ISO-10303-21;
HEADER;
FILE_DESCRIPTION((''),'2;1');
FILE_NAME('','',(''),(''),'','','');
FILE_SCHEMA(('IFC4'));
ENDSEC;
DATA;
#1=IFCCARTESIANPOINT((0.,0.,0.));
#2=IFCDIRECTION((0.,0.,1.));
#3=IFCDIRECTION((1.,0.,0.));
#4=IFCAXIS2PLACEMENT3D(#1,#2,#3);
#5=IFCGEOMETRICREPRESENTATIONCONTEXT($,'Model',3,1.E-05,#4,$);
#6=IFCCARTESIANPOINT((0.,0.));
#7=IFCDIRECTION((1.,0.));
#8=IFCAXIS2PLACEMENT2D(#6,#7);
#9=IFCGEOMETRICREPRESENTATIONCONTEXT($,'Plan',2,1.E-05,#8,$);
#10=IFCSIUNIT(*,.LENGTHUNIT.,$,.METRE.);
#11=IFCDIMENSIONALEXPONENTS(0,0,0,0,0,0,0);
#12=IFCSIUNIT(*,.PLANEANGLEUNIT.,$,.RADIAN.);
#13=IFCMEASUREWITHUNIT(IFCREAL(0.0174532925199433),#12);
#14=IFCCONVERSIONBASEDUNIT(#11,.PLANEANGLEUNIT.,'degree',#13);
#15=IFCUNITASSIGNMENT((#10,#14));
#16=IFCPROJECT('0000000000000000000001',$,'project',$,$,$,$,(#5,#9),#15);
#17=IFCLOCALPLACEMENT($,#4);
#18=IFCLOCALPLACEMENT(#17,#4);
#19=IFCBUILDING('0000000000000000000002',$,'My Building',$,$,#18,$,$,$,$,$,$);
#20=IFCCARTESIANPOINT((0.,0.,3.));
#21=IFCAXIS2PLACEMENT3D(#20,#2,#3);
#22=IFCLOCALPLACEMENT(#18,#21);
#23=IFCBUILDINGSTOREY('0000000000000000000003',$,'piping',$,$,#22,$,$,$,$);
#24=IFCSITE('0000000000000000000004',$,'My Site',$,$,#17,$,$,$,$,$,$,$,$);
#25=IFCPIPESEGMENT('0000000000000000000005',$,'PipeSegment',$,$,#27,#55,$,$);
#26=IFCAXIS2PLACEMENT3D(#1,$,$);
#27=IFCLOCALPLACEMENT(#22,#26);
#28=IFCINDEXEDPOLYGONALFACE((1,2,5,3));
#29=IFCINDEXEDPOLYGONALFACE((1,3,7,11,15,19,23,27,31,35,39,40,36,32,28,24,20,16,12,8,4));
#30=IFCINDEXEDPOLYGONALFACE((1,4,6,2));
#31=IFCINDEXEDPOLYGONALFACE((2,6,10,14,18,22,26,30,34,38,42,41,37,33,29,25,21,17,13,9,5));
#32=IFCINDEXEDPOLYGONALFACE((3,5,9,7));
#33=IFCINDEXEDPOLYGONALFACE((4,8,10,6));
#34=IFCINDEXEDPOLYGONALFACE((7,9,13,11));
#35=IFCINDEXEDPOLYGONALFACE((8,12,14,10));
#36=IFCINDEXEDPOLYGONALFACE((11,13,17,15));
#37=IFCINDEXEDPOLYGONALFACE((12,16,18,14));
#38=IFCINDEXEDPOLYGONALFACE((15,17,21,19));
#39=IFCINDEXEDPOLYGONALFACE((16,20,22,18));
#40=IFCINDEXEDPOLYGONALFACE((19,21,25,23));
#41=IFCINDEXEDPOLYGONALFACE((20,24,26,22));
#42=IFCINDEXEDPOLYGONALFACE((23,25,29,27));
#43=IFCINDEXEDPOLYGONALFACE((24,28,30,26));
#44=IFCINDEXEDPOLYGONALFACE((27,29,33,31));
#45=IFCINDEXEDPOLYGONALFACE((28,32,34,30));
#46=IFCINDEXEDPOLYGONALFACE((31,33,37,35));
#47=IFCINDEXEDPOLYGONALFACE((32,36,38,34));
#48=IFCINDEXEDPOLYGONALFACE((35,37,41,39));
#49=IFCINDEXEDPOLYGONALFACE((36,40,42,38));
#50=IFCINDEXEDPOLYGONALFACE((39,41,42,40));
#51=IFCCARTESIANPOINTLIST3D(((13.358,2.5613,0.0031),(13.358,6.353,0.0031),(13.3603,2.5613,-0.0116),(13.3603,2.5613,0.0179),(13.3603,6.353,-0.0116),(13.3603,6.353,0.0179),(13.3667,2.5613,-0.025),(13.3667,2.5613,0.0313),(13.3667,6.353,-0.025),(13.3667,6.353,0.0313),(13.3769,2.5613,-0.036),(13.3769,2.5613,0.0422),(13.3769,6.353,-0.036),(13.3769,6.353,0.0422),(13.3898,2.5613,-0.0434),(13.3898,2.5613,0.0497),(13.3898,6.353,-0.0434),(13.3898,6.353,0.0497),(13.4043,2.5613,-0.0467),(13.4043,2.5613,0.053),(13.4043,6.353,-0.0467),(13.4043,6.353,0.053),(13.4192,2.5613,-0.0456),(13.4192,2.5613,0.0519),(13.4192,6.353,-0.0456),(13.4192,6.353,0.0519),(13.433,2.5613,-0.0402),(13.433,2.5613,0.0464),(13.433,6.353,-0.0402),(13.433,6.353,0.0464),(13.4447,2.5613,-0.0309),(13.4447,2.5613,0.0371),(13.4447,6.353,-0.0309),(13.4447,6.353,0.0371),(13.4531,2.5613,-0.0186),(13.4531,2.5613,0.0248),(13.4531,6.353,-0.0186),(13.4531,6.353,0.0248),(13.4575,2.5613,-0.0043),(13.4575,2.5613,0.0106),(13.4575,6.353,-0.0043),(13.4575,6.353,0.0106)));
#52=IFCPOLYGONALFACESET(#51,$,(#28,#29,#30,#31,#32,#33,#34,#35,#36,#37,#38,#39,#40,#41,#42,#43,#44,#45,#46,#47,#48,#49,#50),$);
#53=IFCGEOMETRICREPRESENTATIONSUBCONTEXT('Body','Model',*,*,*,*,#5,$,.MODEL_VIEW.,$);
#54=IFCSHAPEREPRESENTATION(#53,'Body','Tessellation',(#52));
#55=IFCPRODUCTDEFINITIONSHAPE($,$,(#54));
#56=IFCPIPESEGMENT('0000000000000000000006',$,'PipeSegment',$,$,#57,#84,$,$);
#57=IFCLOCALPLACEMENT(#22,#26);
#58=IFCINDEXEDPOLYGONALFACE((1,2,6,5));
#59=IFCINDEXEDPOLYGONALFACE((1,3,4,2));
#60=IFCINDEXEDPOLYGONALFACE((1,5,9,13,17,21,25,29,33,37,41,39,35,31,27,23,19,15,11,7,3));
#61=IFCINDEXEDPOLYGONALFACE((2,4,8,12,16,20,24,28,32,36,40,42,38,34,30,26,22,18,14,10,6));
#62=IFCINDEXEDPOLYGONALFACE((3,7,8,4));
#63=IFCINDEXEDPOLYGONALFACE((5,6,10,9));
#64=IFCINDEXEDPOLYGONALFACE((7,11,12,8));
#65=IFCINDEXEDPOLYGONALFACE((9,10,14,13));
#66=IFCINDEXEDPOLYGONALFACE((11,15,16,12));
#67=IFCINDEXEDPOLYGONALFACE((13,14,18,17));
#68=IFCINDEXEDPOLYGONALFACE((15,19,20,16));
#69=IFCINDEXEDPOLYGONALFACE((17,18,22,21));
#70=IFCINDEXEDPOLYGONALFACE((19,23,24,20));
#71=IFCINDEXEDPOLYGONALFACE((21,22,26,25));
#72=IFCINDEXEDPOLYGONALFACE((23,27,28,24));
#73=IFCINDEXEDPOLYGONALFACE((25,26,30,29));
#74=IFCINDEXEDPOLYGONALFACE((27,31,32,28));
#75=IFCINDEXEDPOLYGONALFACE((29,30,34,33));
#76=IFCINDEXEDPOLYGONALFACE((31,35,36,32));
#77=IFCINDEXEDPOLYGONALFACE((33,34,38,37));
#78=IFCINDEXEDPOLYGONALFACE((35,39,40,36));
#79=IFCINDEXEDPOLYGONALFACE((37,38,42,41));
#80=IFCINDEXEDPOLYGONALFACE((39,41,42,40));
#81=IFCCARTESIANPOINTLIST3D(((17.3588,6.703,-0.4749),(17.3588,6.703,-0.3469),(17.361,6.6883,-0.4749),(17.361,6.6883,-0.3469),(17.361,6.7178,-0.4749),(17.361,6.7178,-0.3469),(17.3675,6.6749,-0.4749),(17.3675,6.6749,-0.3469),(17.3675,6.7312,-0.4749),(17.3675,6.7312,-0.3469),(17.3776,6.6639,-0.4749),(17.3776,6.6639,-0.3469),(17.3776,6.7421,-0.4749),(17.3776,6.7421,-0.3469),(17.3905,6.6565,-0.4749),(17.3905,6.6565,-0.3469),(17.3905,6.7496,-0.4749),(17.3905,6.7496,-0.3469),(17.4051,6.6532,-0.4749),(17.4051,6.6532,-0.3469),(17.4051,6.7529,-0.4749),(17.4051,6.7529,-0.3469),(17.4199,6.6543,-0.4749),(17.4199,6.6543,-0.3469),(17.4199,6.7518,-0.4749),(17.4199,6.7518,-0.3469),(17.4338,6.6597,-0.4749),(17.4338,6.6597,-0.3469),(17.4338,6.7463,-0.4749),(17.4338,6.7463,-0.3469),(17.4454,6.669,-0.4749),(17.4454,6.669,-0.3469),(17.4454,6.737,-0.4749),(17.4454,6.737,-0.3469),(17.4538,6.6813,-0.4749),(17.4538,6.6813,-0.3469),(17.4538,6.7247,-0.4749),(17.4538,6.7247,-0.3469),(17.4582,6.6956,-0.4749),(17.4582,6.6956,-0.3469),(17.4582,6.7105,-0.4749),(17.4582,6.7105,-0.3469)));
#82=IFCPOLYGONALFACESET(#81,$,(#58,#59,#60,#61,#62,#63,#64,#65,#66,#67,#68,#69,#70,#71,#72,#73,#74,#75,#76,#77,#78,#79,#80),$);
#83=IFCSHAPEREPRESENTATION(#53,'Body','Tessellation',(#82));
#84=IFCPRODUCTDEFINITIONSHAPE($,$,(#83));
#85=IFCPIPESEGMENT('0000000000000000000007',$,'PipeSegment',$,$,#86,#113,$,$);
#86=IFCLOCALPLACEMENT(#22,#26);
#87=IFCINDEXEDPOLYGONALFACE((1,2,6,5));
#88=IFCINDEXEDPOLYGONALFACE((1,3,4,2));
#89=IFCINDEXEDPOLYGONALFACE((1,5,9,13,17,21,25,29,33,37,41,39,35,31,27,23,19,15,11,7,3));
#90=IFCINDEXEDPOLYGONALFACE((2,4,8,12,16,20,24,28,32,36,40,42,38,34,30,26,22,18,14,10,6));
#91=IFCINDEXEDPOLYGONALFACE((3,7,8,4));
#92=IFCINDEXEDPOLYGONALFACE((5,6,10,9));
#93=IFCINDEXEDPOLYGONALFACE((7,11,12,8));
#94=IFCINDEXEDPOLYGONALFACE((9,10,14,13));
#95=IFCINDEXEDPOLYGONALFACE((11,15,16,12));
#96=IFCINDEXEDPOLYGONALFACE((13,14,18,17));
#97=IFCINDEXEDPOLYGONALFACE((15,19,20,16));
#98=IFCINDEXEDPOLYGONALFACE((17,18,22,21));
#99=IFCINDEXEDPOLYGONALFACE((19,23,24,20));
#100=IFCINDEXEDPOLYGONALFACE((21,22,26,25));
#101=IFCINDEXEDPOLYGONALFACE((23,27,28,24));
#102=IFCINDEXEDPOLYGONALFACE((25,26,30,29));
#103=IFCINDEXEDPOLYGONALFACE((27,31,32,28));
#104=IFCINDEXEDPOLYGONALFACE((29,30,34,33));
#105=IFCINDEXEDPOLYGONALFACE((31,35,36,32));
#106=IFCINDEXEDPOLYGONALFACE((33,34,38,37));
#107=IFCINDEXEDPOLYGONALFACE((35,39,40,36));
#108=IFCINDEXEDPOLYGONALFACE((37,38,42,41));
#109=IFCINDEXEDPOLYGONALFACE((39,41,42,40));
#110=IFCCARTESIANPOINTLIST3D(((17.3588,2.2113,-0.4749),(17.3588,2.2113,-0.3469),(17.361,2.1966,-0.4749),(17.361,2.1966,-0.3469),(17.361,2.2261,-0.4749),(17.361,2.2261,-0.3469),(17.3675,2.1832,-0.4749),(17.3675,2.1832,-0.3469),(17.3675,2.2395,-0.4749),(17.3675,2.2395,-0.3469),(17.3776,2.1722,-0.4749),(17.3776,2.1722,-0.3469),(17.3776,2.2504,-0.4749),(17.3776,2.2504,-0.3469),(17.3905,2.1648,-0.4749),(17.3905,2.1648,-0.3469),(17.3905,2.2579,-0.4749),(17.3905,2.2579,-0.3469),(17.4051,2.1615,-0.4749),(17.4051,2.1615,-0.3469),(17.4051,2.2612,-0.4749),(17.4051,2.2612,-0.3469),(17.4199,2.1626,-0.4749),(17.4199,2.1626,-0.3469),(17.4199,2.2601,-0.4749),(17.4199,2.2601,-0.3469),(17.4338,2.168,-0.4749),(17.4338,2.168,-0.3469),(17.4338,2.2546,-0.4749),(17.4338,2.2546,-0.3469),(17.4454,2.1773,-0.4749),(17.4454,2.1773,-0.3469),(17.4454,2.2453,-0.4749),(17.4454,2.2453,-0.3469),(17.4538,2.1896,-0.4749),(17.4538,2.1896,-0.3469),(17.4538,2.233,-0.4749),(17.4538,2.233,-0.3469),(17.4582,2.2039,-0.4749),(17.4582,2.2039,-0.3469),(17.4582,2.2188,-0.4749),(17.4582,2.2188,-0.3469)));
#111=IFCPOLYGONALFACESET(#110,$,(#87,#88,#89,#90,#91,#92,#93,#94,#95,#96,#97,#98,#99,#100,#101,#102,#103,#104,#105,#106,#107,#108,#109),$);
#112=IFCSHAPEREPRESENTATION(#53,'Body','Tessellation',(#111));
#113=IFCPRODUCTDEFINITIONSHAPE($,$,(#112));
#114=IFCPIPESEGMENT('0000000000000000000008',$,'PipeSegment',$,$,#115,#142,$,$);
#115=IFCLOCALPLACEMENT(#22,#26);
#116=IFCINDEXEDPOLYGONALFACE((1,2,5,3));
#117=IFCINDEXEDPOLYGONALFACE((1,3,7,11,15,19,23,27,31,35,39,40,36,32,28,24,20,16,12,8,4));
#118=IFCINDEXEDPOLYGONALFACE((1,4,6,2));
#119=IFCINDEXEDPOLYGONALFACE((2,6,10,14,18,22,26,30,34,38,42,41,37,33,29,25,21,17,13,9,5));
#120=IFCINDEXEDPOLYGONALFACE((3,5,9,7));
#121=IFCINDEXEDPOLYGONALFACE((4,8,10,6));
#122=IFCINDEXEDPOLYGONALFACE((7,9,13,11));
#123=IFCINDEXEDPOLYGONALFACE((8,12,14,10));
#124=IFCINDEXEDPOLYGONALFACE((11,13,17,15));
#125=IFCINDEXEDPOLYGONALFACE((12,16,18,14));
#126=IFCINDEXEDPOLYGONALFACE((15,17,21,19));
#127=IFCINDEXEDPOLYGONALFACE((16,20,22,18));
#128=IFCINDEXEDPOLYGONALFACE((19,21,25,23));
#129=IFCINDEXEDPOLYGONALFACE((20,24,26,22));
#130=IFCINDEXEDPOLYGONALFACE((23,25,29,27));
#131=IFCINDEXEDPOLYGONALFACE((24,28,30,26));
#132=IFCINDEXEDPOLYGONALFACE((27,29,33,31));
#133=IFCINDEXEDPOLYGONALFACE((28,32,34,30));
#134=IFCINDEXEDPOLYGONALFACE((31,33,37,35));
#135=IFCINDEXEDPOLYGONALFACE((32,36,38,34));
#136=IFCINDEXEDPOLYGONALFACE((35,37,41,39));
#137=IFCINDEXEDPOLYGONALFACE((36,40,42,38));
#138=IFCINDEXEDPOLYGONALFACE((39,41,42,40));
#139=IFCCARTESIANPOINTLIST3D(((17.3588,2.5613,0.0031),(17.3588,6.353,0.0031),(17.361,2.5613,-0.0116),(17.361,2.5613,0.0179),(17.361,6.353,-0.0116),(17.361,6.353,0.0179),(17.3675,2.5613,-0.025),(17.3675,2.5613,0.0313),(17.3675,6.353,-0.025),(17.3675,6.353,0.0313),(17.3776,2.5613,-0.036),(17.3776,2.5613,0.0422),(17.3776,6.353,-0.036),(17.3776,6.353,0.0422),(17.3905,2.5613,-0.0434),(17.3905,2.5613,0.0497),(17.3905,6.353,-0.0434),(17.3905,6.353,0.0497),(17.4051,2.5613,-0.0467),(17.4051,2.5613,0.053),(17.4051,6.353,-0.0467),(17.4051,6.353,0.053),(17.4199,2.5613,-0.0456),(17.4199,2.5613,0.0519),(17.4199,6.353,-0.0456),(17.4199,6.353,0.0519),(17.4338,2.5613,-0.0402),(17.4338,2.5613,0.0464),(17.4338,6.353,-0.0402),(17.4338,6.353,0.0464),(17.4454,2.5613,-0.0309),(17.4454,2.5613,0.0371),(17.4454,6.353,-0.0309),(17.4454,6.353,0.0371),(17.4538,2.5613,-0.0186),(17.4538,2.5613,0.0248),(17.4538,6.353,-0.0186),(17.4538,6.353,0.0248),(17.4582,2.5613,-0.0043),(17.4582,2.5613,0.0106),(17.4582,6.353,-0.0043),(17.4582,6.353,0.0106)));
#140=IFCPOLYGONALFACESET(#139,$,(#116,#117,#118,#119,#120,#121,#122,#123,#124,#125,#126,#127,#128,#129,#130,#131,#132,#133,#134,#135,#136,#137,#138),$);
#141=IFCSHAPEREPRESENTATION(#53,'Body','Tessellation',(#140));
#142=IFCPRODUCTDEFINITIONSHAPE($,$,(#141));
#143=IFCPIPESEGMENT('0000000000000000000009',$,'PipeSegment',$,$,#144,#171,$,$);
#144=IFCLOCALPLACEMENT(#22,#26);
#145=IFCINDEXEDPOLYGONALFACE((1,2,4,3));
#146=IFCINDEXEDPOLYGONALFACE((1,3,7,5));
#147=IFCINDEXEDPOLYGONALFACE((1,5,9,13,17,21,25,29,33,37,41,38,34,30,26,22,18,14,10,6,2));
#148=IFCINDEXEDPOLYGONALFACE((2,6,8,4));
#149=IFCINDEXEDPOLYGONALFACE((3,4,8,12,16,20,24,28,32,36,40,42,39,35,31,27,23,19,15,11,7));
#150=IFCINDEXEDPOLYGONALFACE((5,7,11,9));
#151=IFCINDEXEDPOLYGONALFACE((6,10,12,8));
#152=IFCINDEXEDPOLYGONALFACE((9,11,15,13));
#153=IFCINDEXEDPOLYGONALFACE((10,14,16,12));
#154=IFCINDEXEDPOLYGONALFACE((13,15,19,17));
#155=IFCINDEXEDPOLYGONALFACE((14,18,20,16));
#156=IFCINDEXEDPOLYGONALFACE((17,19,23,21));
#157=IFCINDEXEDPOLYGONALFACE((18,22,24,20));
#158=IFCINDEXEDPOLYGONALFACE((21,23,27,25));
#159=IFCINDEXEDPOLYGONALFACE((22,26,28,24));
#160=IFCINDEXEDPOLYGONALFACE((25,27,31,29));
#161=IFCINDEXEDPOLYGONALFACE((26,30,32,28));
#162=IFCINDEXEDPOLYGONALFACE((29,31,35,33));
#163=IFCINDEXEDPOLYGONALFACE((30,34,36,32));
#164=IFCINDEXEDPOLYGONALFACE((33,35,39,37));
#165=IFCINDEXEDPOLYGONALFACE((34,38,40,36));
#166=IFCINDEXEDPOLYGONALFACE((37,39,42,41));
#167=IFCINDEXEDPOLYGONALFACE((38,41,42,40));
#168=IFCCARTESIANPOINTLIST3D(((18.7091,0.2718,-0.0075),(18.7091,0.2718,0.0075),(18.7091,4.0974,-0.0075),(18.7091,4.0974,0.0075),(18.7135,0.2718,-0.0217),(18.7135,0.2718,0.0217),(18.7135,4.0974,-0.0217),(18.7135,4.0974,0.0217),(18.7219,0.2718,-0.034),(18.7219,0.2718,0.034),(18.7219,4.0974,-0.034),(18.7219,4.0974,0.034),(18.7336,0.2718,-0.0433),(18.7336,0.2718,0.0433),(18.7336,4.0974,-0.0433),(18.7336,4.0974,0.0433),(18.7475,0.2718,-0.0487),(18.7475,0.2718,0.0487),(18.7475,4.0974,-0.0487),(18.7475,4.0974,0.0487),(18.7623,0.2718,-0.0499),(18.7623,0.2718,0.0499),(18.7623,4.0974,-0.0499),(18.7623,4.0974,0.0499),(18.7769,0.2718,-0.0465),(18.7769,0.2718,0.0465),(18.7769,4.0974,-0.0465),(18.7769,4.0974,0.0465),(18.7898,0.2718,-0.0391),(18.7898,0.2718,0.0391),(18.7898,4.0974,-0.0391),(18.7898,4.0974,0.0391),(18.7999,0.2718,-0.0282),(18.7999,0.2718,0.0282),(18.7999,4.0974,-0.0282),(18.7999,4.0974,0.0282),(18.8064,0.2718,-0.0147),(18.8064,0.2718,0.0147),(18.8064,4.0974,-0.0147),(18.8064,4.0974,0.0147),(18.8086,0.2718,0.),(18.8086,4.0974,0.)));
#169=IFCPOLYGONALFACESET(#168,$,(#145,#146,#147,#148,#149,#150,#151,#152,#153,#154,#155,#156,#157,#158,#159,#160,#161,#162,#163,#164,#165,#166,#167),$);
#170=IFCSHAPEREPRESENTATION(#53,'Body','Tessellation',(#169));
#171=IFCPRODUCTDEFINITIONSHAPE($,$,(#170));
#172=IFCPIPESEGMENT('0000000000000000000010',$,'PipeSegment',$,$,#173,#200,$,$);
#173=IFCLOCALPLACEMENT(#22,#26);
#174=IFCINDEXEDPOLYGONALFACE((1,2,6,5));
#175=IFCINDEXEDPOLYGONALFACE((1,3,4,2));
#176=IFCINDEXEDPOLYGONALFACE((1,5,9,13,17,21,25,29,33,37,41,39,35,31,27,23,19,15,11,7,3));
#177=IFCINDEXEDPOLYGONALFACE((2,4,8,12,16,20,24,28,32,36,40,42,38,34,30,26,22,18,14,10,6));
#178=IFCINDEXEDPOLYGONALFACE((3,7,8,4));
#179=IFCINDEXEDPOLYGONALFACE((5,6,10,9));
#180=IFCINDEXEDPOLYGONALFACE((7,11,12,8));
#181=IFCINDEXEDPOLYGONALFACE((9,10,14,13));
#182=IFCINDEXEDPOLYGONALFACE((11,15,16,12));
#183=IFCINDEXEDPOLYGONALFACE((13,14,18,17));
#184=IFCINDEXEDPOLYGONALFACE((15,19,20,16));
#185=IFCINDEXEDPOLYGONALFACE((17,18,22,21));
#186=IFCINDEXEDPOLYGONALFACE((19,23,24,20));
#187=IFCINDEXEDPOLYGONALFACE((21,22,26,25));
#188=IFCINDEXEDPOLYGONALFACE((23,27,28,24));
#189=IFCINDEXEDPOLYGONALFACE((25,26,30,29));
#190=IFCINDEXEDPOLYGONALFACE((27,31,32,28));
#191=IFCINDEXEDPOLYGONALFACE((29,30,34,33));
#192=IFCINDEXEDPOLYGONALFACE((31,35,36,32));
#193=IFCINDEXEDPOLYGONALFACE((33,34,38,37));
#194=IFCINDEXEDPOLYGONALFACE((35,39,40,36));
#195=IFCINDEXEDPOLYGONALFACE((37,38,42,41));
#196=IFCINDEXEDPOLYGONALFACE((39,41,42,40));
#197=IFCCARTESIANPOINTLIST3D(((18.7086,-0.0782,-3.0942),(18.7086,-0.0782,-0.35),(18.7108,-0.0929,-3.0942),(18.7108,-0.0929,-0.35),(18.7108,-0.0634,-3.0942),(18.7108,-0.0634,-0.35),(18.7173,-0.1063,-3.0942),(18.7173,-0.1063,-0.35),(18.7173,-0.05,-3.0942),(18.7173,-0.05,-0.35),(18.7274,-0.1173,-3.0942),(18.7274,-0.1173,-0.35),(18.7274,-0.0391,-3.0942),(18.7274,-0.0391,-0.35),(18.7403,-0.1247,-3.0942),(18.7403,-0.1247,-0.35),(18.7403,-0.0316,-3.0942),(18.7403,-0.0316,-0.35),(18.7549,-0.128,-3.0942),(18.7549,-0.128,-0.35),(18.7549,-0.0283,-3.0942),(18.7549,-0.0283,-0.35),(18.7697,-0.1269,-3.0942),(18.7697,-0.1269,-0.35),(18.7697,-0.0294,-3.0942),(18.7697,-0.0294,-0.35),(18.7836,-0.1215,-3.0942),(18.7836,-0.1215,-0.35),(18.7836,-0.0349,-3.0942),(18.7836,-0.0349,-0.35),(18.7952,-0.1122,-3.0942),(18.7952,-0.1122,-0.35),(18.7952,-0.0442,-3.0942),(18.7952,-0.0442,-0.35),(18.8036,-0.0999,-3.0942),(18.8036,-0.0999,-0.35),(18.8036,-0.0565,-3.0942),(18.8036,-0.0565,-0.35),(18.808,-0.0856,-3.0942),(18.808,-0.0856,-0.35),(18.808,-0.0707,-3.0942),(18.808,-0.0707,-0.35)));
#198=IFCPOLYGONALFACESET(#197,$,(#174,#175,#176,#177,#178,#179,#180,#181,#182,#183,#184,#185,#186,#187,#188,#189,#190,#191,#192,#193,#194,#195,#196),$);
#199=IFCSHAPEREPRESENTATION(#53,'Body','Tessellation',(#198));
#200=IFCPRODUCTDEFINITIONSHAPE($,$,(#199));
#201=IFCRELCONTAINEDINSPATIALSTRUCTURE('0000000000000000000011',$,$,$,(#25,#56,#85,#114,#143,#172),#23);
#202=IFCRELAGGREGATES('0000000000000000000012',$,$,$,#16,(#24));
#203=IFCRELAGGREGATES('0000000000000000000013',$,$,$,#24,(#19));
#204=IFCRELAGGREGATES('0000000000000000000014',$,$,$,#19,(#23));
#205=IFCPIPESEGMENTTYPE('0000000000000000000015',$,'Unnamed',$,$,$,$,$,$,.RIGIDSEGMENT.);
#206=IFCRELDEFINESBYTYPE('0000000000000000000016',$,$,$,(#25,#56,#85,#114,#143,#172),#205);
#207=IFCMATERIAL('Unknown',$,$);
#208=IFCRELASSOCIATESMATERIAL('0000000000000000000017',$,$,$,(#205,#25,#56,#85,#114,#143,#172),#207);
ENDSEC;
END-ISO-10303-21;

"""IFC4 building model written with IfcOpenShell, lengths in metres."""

from ifc_helpers import new_model, entity, si_unit, converted_unit, frame, origin_with_axes, origin_2d_with_axis, place, context, subcontext, project, spatial, circle, extrude, material, material_profile, profile_set, profile_usage, type_object, element, save


model = new_model("IFC4")

# Units and contexts
model_context = context("Model", 3, precision=1e-05, world=origin_with_axes())
plan_context = context("Plan", 2, precision=1e-05, world=origin_2d_with_axis())
body_context = subcontext(model_context, "Body", "Model", "MODEL_VIEW")
ifc_project = project(units=[si_unit("LENGTHUNIT", "METRE"), converted_unit("PLANEANGLEUNIT", "degree", entity("IfcReal", 0.0174532925199433), si_unit("PLANEANGLEUNIT", "RADIAN"), dimensions=[0, 0, 0, 0, 0, 0, 0])], contexts=[model_context, plan_context])

# Site, building, storey
site_placement = place(None, origin_with_axes())
site = spatial("IfcSite", under=ifc_project, at=site_placement, Name="My Site")
building_placement = place(site_placement, origin_with_axes())
building = spatial("IfcBuilding", under=site, at=building_placement, Name="My Building")
storey_placement = place(building_placement, frame((0.0, 0.0, 3.0), z_axis=(0.0, 0.0, 1.0), x_axis=(1.0, 0.0, 0.0)))
storey = spatial("IfcBuildingStorey", under=building, at=storey_placement, Name="piping")

# Pipe segments
ifc_material = material(Name="Unknown")
ifc_material_profile = material_profile(ifc_material, circle(Radius=0.05))
ifc_profile_set = profile_set([ifc_material_profile])
pipe_segment_type = type_object("IfcPipeSegmentType", Name="Unnamed", PredefinedType="RIGIDSEGMENT", material=ifc_profile_set)
ifc_profile_usage_1 = profile_usage(ifc_profile_set, cardinal=5)
pipe_segment_1_placement = place(storey_placement, frame((13.408, 2.5613, 0.0031), z_axis=(0.0, 1.0, 0.0), x_axis=(-1.0, 0.0, 0.0)))
element("IfcPipeSegment", 1, at=pipe_segment_1_placement, inside=storey, type_object=pipe_segment_type, material=ifc_profile_usage_1, Name="PipeSegment", context=body_context, shape_type="SweptSolid", body=[
    extrude(circle(Radius=0.05), origin_with_axes(), (0.0, 0.0, 1.0), 3.7917),
])
ifc_profile_usage_2 = profile_usage(ifc_profile_set, cardinal=5)
pipe_segment_2_placement = place(storey_placement, frame((17.4088, 6.703, -0.3469), z_axis=(0.0, 0.0, -1.0), x_axis=(-1.0, 0.0, 0.0)))
element("IfcPipeSegment", 2, at=pipe_segment_2_placement, inside=storey, type_object=pipe_segment_type, material=ifc_profile_usage_2, Name="PipeSegment", context=body_context, shape_type="SweptSolid", body=[
    extrude(circle(Radius=0.05), origin_with_axes(), (0.0, 0.0, 1.0), 0.128),
])
ifc_profile_usage_3 = profile_usage(ifc_profile_set, cardinal=5)
pipe_segment_3_placement = place(storey_placement, frame((17.4088, 2.2113, -0.3469), z_axis=(0.0, 0.0, -1.0), x_axis=(-1.0, 0.0, 0.0)))
element("IfcPipeSegment", 3, at=pipe_segment_3_placement, inside=storey, type_object=pipe_segment_type, material=ifc_profile_usage_3, Name="PipeSegment", context=body_context, shape_type="SweptSolid", body=[
    extrude(circle(Radius=0.05), origin_with_axes(), (0.0, 0.0, 1.0), 0.128),
])
ifc_profile_usage_4 = profile_usage(ifc_profile_set, cardinal=5)
pipe_segment_4_placement = place(storey_placement, frame((17.4088, 2.5613, 0.0031), z_axis=(0.0, 1.0, 0.0), x_axis=(-1.0, 0.0, 0.0)))
element("IfcPipeSegment", 4, at=pipe_segment_4_placement, inside=storey, type_object=pipe_segment_type, material=ifc_profile_usage_4, Name="PipeSegment", context=body_context, shape_type="SweptSolid", body=[
    extrude(circle(Radius=0.05), origin_with_axes(), (0.0, 0.0, 1.0), 3.7917),
])
ifc_profile_usage_5 = profile_usage(ifc_profile_set, cardinal=5)
pipe_segment_5_placement = place(storey_placement, frame((18.7586, 4.0974, 0.0), z_axis=(0.0, -1.0, 0.0), x_axis=(1.0, 0.0, 0.0)))
element("IfcPipeSegment", 5, at=pipe_segment_5_placement, inside=storey, type_object=pipe_segment_type, material=ifc_profile_usage_5, Name="PipeSegment", context=body_context, shape_type="SweptSolid", body=[
    extrude(circle(Radius=0.05), origin_with_axes(), (0.0, 0.0, 1.0), 3.8256),
])
ifc_profile_usage_6 = profile_usage(ifc_profile_set, cardinal=5)
pipe_segment_6_placement = place(storey_placement, frame((18.7586, -0.0782, -0.35), z_axis=(0.0, 0.0, -1.0), x_axis=(-1.0, 0.0, 0.0)))
element("IfcPipeSegment", 6, at=pipe_segment_6_placement, inside=storey, type_object=pipe_segment_type, material=ifc_profile_usage_6, Name="PipeSegment", context=body_context, shape_type="SweptSolid", body=[
    extrude(circle(Radius=0.05), origin_with_axes(), (0.0, 0.0, 1.0), 2.7442),
])

save(model, "model.ifc")
